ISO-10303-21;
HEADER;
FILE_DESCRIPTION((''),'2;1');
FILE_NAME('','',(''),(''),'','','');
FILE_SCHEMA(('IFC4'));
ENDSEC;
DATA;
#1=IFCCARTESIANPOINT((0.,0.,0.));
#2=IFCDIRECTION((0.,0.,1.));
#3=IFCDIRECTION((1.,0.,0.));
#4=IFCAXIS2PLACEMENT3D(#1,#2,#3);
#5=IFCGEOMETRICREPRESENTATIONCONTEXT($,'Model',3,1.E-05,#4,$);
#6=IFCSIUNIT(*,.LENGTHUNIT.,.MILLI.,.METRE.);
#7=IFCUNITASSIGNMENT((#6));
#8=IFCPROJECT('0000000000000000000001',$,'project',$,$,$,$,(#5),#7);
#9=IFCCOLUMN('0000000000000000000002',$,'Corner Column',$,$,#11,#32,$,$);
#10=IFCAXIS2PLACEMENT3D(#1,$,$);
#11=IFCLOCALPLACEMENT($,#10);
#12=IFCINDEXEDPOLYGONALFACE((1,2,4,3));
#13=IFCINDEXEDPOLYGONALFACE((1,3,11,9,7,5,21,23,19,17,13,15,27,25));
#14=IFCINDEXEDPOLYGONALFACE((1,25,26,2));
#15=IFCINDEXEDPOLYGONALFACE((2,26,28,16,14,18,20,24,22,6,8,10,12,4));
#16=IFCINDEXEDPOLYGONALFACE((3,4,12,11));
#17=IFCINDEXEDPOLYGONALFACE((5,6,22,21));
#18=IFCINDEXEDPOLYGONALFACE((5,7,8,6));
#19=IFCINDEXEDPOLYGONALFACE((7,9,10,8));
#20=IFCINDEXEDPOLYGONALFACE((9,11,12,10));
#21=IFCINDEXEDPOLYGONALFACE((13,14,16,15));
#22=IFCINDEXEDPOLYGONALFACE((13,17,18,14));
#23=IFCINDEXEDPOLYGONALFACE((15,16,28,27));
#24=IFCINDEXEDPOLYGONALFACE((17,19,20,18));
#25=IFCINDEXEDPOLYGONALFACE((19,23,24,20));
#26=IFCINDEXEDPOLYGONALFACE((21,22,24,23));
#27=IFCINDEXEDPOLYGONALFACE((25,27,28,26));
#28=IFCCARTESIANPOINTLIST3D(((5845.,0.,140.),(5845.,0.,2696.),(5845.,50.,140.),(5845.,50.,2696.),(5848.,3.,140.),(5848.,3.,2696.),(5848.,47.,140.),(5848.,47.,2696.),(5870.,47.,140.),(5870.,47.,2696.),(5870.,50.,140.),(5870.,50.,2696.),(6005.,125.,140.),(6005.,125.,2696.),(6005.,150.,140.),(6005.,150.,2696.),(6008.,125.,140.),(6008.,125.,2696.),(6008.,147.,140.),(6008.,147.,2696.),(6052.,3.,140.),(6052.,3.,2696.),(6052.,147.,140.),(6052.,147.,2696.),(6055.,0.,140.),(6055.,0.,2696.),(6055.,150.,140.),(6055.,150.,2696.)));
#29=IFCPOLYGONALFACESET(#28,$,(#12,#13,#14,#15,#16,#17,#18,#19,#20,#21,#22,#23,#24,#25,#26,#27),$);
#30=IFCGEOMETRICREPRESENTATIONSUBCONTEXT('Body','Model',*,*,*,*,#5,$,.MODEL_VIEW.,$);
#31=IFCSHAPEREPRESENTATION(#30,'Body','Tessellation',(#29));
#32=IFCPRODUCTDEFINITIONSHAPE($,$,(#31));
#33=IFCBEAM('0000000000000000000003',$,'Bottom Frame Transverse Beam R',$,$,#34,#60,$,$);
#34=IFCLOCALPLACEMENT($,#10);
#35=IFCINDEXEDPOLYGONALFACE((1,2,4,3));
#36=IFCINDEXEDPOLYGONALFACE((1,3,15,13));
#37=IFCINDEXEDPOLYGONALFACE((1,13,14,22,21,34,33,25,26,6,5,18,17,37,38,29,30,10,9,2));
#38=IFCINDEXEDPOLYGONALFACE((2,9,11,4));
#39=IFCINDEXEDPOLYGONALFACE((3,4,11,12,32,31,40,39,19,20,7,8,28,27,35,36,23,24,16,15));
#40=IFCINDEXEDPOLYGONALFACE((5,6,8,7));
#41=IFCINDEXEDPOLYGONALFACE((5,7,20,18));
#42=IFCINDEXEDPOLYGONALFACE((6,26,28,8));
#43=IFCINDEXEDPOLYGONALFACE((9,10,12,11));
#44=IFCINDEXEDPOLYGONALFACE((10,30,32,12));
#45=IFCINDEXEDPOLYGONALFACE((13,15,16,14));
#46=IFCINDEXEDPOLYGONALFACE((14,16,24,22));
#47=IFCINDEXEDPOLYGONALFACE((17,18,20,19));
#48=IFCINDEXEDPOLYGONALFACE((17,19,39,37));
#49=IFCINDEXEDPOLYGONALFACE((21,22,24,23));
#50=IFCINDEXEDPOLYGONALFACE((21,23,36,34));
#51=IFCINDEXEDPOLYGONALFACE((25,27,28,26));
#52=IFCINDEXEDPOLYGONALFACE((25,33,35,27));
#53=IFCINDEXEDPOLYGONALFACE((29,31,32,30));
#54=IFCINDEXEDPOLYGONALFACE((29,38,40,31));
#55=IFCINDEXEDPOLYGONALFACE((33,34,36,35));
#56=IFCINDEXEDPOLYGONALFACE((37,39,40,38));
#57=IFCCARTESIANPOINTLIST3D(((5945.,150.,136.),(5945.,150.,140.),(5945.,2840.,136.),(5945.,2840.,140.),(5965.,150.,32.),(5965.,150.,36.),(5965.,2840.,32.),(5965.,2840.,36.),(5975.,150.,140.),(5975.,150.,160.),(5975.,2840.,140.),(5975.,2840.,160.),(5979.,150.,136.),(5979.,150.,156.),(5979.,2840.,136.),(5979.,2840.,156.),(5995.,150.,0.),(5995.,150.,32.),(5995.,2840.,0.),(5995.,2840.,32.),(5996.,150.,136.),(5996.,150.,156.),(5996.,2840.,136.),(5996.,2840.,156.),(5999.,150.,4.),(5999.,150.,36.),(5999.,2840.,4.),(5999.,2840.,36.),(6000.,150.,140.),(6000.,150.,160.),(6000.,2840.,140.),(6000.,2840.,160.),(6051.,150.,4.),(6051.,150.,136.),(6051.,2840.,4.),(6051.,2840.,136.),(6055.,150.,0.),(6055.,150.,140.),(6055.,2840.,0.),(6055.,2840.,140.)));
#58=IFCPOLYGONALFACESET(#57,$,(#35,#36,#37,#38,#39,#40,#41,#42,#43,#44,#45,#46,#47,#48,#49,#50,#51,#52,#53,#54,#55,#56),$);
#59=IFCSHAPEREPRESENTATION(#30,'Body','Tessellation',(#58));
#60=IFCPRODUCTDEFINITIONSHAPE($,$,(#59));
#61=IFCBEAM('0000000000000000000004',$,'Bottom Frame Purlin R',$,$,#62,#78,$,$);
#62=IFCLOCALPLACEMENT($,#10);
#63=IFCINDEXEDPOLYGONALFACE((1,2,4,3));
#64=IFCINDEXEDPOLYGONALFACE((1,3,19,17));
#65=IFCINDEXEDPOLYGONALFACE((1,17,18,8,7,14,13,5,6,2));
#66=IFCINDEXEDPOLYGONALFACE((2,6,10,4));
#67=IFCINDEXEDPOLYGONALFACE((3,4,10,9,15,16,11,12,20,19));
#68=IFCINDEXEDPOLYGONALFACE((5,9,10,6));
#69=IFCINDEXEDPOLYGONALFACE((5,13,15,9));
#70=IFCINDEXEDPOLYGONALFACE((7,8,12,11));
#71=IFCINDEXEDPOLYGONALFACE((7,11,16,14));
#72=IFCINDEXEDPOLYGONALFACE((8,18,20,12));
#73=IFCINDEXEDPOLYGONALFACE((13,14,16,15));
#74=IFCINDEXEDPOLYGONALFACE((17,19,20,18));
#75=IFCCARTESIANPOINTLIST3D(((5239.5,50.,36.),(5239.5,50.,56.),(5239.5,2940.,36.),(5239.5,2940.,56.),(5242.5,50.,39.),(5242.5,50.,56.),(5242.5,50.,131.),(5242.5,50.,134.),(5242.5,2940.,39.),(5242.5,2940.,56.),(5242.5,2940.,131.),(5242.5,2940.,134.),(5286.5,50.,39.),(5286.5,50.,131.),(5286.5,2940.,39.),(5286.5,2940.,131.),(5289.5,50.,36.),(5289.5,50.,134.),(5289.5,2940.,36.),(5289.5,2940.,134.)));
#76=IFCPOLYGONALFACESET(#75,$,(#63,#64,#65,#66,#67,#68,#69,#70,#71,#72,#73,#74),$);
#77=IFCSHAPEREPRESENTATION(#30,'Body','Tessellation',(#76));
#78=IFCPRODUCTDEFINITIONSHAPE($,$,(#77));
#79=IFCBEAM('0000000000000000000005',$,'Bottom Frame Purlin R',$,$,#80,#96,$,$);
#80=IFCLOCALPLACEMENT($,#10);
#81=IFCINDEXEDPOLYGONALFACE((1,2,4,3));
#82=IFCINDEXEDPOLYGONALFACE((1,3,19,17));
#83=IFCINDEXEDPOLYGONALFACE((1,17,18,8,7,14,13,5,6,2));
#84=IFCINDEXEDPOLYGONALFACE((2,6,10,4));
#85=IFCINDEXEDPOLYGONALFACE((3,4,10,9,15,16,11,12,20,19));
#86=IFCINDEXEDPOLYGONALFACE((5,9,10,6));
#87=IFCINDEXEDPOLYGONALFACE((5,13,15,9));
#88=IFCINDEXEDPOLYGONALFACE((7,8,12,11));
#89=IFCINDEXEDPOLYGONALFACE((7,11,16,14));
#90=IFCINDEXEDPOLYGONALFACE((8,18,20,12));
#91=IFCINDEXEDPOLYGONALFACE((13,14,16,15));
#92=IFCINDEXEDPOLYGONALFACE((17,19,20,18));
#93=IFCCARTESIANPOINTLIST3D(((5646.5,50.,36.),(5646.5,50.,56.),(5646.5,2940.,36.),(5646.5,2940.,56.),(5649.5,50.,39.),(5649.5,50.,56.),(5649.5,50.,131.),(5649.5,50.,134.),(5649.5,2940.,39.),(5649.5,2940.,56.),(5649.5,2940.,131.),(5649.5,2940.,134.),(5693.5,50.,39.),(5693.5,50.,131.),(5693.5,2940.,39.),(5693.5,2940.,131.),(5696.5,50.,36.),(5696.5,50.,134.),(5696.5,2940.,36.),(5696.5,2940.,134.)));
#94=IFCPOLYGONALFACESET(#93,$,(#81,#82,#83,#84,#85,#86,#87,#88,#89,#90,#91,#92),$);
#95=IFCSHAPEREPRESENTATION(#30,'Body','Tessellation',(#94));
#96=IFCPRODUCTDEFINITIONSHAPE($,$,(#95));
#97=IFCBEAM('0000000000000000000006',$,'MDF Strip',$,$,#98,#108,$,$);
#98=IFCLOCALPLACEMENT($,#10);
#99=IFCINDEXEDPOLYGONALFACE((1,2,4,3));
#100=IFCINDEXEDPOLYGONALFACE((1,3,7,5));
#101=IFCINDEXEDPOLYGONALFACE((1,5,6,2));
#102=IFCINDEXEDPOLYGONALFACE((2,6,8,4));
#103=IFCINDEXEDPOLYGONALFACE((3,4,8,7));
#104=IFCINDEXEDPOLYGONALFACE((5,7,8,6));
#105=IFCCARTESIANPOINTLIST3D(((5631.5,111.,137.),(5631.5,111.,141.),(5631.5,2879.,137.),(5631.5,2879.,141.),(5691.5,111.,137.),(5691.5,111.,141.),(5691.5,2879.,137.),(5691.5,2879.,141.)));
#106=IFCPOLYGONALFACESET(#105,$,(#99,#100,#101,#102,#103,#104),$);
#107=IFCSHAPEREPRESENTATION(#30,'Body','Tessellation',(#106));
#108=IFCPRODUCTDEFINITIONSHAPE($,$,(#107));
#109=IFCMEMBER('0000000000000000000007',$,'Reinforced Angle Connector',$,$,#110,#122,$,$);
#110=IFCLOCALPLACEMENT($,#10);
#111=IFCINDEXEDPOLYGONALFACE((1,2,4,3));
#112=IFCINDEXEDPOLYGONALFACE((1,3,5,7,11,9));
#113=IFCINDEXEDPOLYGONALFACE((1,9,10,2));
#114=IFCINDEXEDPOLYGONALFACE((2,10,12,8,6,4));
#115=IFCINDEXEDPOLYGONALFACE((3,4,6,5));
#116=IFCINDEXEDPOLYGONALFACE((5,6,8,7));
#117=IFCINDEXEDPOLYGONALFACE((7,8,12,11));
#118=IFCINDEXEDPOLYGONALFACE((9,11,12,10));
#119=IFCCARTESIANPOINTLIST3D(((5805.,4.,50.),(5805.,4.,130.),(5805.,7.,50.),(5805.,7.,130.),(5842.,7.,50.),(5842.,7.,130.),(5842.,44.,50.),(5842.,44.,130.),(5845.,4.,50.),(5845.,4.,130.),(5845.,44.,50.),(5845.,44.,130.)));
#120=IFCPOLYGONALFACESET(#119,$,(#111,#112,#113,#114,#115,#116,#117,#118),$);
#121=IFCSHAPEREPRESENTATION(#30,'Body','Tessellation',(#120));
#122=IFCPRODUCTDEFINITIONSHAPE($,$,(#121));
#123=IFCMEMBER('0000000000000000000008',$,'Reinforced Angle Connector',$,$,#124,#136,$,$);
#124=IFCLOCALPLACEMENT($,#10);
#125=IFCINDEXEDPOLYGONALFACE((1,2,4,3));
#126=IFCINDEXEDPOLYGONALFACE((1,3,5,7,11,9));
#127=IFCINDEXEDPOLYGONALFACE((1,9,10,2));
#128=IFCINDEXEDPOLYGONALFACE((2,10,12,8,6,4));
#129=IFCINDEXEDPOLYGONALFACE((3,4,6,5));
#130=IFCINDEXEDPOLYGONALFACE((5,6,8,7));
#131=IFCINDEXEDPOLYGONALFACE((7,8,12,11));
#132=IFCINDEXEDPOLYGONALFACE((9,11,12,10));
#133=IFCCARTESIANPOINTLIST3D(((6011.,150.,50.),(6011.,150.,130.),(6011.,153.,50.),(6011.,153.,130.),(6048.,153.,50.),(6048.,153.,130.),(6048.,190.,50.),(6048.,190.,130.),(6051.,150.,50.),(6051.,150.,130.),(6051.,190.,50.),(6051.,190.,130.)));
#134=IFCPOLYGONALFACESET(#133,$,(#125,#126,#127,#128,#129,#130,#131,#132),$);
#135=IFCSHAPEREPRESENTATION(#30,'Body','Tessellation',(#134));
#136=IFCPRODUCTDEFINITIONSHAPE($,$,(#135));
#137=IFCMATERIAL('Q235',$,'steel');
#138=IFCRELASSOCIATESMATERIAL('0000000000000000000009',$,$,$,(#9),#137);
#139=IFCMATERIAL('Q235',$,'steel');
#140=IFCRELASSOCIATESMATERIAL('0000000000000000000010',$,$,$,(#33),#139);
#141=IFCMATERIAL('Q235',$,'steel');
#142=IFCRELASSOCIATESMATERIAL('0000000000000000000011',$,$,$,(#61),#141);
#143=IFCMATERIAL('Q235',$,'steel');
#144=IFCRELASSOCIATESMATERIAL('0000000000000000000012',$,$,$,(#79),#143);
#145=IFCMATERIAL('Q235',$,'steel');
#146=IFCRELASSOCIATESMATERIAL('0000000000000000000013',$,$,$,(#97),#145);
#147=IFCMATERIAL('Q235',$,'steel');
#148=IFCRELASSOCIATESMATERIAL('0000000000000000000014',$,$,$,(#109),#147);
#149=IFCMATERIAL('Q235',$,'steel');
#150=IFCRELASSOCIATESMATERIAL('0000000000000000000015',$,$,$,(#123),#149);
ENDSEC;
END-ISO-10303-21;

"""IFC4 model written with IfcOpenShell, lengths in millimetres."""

from ifc_helpers import new_model, si_unit, frame, origin_with_axes, place, context, subcontext, project, line, indexed_curve, outline, extrude, material, element, save


model = new_model("IFC4")

# Units and contexts
model_context = context("Model", 3, precision=1e-05, world=origin_with_axes())
body_context = subcontext(model_context, "Body", "Model", "MODEL_VIEW")
ifc_project = project(units=[si_unit("LENGTHUNIT", "METRE", prefix="MILLI")], contexts=[model_context])

# Column
ifc_material_1 = material(Name="Q235", Category="steel")
column_placement = place(None, frame((6055.0, 0.0, 140.0), z_axis=(0.0, 0.0, 1.0), x_axis=(0.0, 1.0, 0.0)))
element("IfcColumn", 1, at=column_placement, material=ifc_material_1, Name="Corner Column", context=body_context, shape_type="SweptSolid", body=[
    extrude(outline(indexed_curve([(0.0, 0.0), (0.0, 210.0), (50.0, 210.0), (50.0, 185.0), (47.0, 185.0), (47.0, 207.0), (3.0, 207.0), (3.0, 3.0), (147.0, 3.0), (147.0, 47.0), (125.0, 47.0), (125.0, 50.0), (150.0, 50.0), (150.0, 0.0), (0.0, 0.0)], segments=[line(1, 2, 3, 4, 5, 6, 7, 8, 9, 10, 11, 12, 13, 14, 15, 1)])), origin_with_axes(), (0.0, 0.0, 1.0), 2556.0),
])

# Beams
ifc_material_2 = material(Name="Q235", Category="steel")
beam_1_placement = place(None, frame((6055.0, 150.0, 0.0), z_axis=(0.0, 1.0, 0.0), x_axis=(-1.0, 0.0, 0.0)))
element("IfcBeam", 2, at=beam_1_placement, material=ifc_material_2, Name="Bottom Frame Transverse Beam R", context=body_context, shape_type="SweptSolid", body=[
    extrude(outline(indexed_curve([(0.0, 0.0), (60.0, 0.0), (60.0, 32.0), (90.0, 32.0), (90.0, 36.0), (56.0, 36.0), (56.0, 4.0), (4.0, 4.0), (4.0, 136.0), (59.0, 136.0), (59.0, 156.0), (76.0, 156.0), (76.0, 136.0), (110.0, 136.0), (110.0, 140.0), (80.0, 140.0), (80.0, 160.0), (55.0, 160.0), (55.0, 140.0), (0.0, 140.0), (0.0, 0.0)], segments=[line(1, 2, 3, 4, 5, 6, 7, 8, 9, 10, 11, 12, 13, 14, 15, 16, 17, 18, 19, 20, 21, 1)])), origin_with_axes(), (0.0, 0.0, 1.0), 2690.0),
])
ifc_material_3 = material(Name="Q235", Category="steel")
beam_2_placement = place(None, frame((5289.5, 50.0, 36.0), z_axis=(0.0, 1.0, 0.0), x_axis=(-1.0, 0.0, 0.0)))
element("IfcBeam", 3, at=beam_2_placement, material=ifc_material_3, Name="Bottom Frame Purlin R", context=body_context, shape_type="SweptSolid", body=[
    extrude(outline(indexed_curve([(0.0, 0.0), (50.0, 0.0), (50.0, 20.0), (47.0, 20.0), (47.0, 3.0), (3.0, 3.0), (3.0, 95.0), (47.0, 95.0), (47.0, 138.0), (50.0, 78.0), (50.0, 98.0), (0.0, 98.0), (0.0, 0.0)], segments=[line(1, 2, 3, 4, 5, 6, 7, 8, 9, 10, 11, 12, 13, 1)])), origin_with_axes(), (0.0, 0.0, 1.0), 2890.0),
])
ifc_material_4 = material(Name="Q235", Category="steel")
beam_3_placement = place(None, frame((5696.5, 50.0, 36.0), z_axis=(0.0, 1.0, 0.0), x_axis=(-1.0, 0.0, 0.0)))
element("IfcBeam", 4, at=beam_3_placement, material=ifc_material_4, Name="Bottom Frame Purlin R", context=body_context, shape_type="SweptSolid", body=[
    extrude(outline(indexed_curve([(0.0, 0.0), (50.0, 0.0), (50.0, 20.0), (47.0, 20.0), (47.0, 3.0), (3.0, 3.0), (3.0, 95.0), (47.0, 95.0), (47.0, 138.0), (50.0, 78.0), (50.0, 98.0), (0.0, 98.0), (0.0, 0.0)], segments=[line(1, 2, 3, 4, 5, 6, 7, 8, 9, 10, 11, 12, 13, 1)])), origin_with_axes(), (0.0, 0.0, 1.0), 2890.0),
])
ifc_material_5 = material(Name="Q235", Category="steel")
beam_4_placement = place(None, frame((5631.5, 111.0, 137.0), z_axis=(0.0, 1.0, 0.0), x_axis=(1.0, 0.0, 0.0)))
element("IfcBeam", 5, at=beam_4_placement, material=ifc_material_5, Name="MDF Strip", context=body_context, shape_type="SweptSolid", body=[
    extrude(outline(indexed_curve([(0.0, 0.0), (60.0, 0.0), (60.0, -4.0), (0.0, -4.0), (0.0, 0.0)], segments=[line(1, 2, 3, 4, 5, 1)])), origin_with_axes(), (0.0, 0.0, 1.0), 2768.0),
])

# Members
ifc_material_6 = material(Name="Q235", Category="steel")
member_1_placement = place(None, frame((5845.0, 4.0, 50.0), z_axis=(0.0, 0.0, 1.0), x_axis=(0.0, 1.0, 0.0)))
element("IfcMember", 6, at=member_1_placement, material=ifc_material_6, Name="Reinforced Angle Connector", context=body_context, shape_type="SweptSolid", body=[
    extrude(outline(indexed_curve([(0.0, 0.0), (0.0, 40.0), (3.0, 40.0), (3.0, 3.0), (40.0, 3.0), (40.0, 0.0), (0.0, 0.0)], segments=[line(1, 2, 3, 4, 5, 6, 7, 1)])), origin_with_axes(), (0.0, 0.0, 1.0), 80.0),
])
ifc_material_7 = material(Name="Q235", Category="steel")
member_2_placement = place(None, frame((6051.0, 150.0, 50.0), z_axis=(0.0, 0.0, 1.0), x_axis=(0.0, 1.0, 0.0)))
element("IfcMember", 7, at=member_2_placement, material=ifc_material_7, Name="Reinforced Angle Connector", context=body_context, shape_type="SweptSolid", body=[
    extrude(outline(indexed_curve([(0.0, 0.0), (0.0, 40.0), (3.0, 40.0), (3.0, 3.0), (40.0, 3.0), (40.0, 0.0), (0.0, 0.0)], segments=[line(1, 2, 3, 4, 5, 6, 7, 1)])), origin_with_axes(), (0.0, 0.0, 1.0), 80.0),
])

save(model, "model.ifc")
